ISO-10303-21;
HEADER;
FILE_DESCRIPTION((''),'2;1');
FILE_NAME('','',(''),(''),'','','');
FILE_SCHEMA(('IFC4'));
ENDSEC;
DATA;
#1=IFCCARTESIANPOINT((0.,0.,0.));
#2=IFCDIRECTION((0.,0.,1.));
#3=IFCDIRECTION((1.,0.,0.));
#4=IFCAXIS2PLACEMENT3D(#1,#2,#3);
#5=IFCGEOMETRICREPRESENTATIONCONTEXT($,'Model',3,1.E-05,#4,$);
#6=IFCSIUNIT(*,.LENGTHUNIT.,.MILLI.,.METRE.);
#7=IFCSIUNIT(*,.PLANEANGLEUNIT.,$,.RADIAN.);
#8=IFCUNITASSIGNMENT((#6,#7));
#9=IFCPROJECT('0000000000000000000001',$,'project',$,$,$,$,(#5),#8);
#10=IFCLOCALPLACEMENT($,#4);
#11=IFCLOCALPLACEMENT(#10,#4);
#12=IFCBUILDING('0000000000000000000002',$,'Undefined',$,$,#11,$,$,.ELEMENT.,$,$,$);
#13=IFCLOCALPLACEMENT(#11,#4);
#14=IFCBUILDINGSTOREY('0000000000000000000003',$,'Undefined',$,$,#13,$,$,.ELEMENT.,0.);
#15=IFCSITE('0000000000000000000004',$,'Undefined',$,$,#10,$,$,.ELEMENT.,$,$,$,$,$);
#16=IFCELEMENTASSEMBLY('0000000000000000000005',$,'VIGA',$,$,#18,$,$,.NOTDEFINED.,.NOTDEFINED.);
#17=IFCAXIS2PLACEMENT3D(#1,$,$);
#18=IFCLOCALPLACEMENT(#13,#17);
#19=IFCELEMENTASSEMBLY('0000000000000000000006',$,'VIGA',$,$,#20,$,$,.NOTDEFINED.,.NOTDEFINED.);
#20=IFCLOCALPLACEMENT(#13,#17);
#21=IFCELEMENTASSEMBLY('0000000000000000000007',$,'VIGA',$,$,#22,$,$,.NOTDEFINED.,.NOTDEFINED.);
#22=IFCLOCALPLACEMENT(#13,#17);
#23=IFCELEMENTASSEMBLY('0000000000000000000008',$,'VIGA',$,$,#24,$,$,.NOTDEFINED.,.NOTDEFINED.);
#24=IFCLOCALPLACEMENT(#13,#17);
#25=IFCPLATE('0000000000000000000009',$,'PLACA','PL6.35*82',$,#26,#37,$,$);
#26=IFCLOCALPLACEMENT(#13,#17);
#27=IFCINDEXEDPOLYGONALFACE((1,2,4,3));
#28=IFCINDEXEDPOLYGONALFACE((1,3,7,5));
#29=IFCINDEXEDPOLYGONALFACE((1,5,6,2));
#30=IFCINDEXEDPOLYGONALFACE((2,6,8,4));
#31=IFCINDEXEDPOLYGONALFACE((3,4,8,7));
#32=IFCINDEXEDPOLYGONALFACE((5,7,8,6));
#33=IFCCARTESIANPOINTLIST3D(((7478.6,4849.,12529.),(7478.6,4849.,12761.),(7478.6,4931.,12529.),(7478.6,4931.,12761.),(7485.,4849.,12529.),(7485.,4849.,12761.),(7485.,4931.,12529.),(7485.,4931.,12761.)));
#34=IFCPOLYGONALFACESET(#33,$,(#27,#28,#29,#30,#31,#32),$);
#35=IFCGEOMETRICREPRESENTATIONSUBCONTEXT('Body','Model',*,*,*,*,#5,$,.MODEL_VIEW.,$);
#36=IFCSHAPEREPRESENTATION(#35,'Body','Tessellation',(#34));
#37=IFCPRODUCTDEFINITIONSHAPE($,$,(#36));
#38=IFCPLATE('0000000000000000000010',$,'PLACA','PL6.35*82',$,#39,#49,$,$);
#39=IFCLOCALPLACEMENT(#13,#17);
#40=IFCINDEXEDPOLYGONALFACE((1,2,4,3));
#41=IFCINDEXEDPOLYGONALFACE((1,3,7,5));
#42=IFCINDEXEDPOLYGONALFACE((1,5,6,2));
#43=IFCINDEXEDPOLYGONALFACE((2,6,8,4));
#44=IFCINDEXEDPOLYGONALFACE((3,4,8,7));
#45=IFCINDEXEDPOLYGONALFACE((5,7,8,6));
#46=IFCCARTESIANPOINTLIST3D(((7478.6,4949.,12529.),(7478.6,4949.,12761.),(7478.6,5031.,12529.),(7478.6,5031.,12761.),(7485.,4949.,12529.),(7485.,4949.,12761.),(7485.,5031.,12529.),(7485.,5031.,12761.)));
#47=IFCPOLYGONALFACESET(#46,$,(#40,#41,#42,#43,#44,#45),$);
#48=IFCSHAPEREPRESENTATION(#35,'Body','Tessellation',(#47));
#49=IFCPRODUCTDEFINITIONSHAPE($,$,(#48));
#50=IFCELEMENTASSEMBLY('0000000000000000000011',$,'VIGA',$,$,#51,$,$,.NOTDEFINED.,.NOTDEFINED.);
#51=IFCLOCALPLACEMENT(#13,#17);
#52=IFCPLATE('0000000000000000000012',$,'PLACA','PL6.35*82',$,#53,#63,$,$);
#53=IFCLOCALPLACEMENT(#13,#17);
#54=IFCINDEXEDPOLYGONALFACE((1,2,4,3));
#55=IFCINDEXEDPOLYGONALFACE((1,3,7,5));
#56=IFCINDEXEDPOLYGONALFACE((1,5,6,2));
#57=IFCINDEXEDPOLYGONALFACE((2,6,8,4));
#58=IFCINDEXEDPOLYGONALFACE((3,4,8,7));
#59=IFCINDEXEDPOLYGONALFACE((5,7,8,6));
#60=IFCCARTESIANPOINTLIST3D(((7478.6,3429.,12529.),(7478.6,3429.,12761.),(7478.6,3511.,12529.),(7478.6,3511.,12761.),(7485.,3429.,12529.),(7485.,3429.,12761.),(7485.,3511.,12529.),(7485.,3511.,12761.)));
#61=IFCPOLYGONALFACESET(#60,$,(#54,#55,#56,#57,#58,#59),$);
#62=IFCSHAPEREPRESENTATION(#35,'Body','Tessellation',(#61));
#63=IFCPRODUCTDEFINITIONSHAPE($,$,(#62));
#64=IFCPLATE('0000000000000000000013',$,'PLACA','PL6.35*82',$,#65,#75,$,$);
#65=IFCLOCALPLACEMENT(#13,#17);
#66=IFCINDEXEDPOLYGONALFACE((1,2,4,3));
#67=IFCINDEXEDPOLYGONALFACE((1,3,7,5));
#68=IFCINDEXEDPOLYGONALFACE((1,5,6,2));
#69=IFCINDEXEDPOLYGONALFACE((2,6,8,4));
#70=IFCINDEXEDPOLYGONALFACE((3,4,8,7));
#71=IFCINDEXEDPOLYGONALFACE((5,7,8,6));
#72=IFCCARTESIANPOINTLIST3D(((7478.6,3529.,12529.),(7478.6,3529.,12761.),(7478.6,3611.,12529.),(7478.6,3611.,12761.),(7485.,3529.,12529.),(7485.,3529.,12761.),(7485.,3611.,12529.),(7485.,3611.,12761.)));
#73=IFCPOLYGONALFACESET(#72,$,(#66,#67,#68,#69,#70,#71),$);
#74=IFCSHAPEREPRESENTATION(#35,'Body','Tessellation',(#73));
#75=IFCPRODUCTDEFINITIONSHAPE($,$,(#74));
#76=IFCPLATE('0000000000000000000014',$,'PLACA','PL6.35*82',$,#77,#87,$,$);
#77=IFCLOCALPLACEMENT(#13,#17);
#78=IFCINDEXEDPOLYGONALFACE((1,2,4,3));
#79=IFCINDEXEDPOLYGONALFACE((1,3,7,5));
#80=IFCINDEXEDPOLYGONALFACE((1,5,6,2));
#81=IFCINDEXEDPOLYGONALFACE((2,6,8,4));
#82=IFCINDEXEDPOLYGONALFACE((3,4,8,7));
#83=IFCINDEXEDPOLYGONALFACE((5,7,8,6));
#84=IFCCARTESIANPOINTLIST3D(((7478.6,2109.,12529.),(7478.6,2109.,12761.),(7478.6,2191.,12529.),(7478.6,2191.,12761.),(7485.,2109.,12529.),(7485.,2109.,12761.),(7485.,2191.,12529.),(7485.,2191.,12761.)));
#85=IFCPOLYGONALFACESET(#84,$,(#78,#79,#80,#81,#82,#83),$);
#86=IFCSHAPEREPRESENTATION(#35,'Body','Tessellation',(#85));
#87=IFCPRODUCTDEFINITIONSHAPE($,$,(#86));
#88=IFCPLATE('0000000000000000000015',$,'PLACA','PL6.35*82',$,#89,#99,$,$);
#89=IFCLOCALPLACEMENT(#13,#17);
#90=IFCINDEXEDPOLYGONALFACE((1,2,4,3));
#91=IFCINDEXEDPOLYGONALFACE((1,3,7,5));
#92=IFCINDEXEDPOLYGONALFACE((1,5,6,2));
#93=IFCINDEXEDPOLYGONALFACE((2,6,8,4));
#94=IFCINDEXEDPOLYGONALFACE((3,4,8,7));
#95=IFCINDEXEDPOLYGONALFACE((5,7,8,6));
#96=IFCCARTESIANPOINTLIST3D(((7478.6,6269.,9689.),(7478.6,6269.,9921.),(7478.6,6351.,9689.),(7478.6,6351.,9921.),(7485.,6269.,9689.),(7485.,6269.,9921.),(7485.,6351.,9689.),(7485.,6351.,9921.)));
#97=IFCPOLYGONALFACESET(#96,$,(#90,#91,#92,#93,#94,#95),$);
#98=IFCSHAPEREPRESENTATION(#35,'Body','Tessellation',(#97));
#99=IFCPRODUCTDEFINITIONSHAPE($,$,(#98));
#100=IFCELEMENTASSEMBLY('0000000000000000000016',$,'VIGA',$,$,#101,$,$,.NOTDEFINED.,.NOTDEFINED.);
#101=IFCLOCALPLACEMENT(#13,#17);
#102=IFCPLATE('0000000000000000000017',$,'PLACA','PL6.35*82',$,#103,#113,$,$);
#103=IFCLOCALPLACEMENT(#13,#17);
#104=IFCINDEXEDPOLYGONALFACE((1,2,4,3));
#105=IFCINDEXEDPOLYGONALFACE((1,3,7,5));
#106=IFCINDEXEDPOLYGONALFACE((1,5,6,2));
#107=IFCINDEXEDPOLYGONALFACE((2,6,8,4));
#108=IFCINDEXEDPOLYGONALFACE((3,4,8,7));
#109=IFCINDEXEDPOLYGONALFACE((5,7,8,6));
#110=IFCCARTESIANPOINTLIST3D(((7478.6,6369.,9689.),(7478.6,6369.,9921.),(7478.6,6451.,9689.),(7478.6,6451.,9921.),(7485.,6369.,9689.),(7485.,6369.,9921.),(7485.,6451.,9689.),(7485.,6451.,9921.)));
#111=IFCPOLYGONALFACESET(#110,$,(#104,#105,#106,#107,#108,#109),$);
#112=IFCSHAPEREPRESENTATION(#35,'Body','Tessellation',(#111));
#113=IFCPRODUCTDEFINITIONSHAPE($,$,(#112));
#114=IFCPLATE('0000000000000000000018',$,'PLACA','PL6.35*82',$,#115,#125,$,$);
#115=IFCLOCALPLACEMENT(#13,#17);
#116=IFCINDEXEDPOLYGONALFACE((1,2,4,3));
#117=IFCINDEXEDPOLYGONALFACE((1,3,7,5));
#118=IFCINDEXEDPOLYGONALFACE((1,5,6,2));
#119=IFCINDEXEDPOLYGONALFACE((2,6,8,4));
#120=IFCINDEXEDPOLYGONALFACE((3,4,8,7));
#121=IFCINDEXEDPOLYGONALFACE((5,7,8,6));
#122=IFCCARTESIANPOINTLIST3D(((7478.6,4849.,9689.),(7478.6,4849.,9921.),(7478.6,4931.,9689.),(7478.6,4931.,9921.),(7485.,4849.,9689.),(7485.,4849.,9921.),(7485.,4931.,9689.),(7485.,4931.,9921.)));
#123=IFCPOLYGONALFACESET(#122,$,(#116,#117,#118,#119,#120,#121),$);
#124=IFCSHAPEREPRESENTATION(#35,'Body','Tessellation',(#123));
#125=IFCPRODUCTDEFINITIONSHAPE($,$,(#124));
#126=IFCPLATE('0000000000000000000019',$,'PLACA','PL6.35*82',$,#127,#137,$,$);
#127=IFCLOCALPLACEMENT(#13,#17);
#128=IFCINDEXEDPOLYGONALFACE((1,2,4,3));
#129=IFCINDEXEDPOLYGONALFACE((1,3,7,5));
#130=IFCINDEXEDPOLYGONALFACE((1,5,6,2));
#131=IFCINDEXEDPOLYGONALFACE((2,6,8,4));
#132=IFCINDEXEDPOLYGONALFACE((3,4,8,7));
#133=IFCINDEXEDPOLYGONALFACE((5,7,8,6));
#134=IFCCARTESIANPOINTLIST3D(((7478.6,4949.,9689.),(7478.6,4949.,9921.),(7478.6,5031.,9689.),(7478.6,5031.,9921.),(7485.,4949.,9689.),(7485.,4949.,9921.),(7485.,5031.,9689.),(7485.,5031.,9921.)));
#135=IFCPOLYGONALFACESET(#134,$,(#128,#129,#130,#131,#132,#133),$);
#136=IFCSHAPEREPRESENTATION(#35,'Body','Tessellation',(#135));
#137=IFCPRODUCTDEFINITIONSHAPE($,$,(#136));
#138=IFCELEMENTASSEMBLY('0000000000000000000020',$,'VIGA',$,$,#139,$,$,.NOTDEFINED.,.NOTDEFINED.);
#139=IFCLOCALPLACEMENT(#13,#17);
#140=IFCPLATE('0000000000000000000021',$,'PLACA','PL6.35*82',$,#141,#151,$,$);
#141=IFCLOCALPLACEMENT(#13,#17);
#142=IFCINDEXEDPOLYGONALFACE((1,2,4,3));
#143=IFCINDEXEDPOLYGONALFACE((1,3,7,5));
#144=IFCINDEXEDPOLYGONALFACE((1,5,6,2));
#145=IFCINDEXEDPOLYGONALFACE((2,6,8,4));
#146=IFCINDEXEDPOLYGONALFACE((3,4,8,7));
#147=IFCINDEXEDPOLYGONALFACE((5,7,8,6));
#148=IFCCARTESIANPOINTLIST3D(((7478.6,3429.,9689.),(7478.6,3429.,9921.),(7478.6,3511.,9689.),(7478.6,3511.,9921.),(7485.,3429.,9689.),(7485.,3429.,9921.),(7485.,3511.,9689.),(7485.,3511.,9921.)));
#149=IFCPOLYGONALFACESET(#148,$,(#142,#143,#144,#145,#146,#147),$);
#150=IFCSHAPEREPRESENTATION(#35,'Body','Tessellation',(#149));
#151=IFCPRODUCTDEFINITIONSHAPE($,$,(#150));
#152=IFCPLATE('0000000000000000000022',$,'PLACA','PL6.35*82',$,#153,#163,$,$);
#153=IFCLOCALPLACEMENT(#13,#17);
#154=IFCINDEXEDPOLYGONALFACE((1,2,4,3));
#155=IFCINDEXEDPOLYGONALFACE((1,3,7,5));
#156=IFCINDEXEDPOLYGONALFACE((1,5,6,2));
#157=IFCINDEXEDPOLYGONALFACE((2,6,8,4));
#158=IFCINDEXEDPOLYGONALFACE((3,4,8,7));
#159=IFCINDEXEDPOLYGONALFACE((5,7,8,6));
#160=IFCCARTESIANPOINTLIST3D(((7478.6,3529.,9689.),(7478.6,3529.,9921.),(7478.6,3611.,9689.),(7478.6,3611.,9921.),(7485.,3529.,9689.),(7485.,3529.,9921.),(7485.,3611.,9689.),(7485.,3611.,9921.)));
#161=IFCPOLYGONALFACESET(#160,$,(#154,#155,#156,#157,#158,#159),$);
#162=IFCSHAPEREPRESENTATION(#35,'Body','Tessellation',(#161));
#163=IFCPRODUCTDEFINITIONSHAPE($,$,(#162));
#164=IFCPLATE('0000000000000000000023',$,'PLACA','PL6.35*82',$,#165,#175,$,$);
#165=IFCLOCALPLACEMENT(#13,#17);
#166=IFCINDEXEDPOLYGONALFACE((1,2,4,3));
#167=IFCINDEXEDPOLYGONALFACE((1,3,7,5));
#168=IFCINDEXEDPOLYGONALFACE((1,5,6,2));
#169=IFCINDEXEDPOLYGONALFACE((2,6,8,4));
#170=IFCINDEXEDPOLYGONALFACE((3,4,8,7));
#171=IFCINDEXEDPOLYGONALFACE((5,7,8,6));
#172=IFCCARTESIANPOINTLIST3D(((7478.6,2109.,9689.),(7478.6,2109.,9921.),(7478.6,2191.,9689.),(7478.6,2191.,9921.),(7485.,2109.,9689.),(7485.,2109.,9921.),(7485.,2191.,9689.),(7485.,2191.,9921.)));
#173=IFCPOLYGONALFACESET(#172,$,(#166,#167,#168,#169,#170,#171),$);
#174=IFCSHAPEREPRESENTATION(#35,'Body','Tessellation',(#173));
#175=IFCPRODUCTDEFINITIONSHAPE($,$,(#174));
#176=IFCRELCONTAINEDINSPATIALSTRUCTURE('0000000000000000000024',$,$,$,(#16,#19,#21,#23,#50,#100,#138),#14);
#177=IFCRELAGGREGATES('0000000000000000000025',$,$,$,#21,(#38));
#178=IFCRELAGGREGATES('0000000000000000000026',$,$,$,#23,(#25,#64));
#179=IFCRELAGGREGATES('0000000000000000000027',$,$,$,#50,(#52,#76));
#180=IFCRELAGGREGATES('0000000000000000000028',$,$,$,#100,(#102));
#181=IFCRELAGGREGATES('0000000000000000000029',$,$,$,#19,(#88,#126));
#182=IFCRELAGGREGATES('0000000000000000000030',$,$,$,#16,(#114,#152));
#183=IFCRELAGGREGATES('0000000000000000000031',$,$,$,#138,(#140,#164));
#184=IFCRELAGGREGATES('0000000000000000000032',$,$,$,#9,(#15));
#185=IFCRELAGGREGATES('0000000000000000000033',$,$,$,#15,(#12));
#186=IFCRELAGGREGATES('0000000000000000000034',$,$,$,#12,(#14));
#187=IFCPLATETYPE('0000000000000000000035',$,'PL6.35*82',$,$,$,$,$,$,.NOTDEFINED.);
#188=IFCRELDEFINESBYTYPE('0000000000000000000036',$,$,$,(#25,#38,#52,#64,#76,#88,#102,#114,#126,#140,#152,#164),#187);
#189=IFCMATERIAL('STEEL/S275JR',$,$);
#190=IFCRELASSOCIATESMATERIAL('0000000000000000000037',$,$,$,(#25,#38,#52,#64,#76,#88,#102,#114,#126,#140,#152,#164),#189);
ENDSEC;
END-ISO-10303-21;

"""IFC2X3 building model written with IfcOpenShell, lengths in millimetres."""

from ifc_helpers import new_model, si_unit, frame, origin_with_axes, place, context, subcontext, project, spatial, polyline, outline, extrude, material, type_object, element, aggregate, save


model = new_model("IFC2X3")

# Units and contexts
model_context = context("Model", 3, precision=1e-05, world=origin_with_axes())
body_context = subcontext(model_context, "Body", "Model", "MODEL_VIEW")
ifc_project = project(units=[si_unit("LENGTHUNIT", "METRE", prefix="MILLI"), si_unit("PLANEANGLEUNIT", "RADIAN")], contexts=[model_context])

# Site, building, storey
site_placement = place(None, origin_with_axes())
site = spatial("IfcSite", under=ifc_project, at=site_placement, Name="Undefined", CompositionType="ELEMENT")
building_placement = place(site_placement, origin_with_axes())
building = spatial("IfcBuilding", under=site, at=building_placement, Name="Undefined", CompositionType="ELEMENT")
storey_placement = place(building_placement, origin_with_axes())
storey = spatial("IfcBuildingStorey", under=building, at=storey_placement, Name="Undefined", CompositionType="ELEMENT", Elevation=0.0)

# Shared definitions
ifc_material_1 = material(Name="STEEL/S275JR")

# Element assembly
assembly_1_placement = place(storey_placement, origin_with_axes())
assembly_1 = element("IfcElementAssembly", 1, at=assembly_1_placement, inside=storey, Name="VIGA", AssemblyPlace="NOTDEFINED", PredefinedType="NOTDEFINED")

# Element assemblies, plate
assembly_2_placement = place(storey_placement, origin_with_axes())
assembly_2 = element("IfcElementAssembly", 2, at=assembly_2_placement, inside=storey, Name="VIGA", AssemblyPlace="NOTDEFINED", PredefinedType="NOTDEFINED")
assembly_3_placement = place(storey_placement, origin_with_axes())
assembly_3 = element("IfcElementAssembly", 3, at=assembly_3_placement, inside=storey, Name="VIGA", AssemblyPlace="NOTDEFINED", PredefinedType="NOTDEFINED")
plate_type_1 = type_object("IfcPlateType", Name="PL6.35*82", PredefinedType="NOTDEFINED")
assembly_4_placement = place(storey_placement, origin_with_axes())
assembly_4 = element("IfcElementAssembly", 4, at=assembly_4_placement, inside=storey, Name="VIGA", AssemblyPlace="NOTDEFINED", PredefinedType="NOTDEFINED")
plate_1_placement = place(assembly_4_placement, frame((7481.8, 4849.0, 12761.0), z_axis=(-1.0, 0.0, 0.0), x_axis=(0.0, 1.0, 0.0)))
plate_1 = element("IfcPlate", 5, at=plate_1_placement, type_object=plate_type_1, material=ifc_material_1, Name="PLACA", Description="PL6.35*82", context=body_context, shape_type="SweptSolid", body=[
    extrude(outline(polyline([(0.0, 0.0), (82.0, 0.0), (82.0, 232.0), (0.0, 232.0), (0.0, 0.0)])), frame((0.0, 0.0, -3.2), z_axis=(0.0, 0.0, 1.0), x_axis=(1.0, 0.0, 0.0)), (0.0, 0.0, 1.0), 6.4),
])

# Plate
plate_2_placement = place(assembly_3_placement, frame((7481.8, 4949.0, 12761.0), z_axis=(-1.0, 0.0, 0.0), x_axis=(0.0, 1.0, 0.0)))
plate_2 = element("IfcPlate", 6, at=plate_2_placement, type_object=plate_type_1, material=ifc_material_1, Name="PLACA", Description="PL6.35*82", context=body_context, shape_type="SweptSolid", body=[
    extrude(outline(polyline([(0.0, 0.0), (82.0, 0.0), (82.0, 232.0), (0.0, 232.0), (0.0, 0.0)])), frame((0.0, 0.0, -3.2), z_axis=(0.0, 0.0, 1.0), x_axis=(1.0, 0.0, 0.0)), (0.0, 0.0, 1.0), 6.4),
])
aggregate(assembly_3, [plate_2])

# Element assembly, plate
assembly_5_placement = place(storey_placement, origin_with_axes())
assembly_5 = element("IfcElementAssembly", 7, at=assembly_5_placement, inside=storey, Name="VIGA", AssemblyPlace="NOTDEFINED", PredefinedType="NOTDEFINED")
plate_3_placement = place(assembly_5_placement, frame((7481.8, 3429.0, 12761.0), z_axis=(-1.0, 0.0, 0.0), x_axis=(0.0, 1.0, 0.0)))
plate_3 = element("IfcPlate", 8, at=plate_3_placement, type_object=plate_type_1, material=ifc_material_1, Name="PLACA", Description="PL6.35*82", context=body_context, shape_type="SweptSolid", body=[
    extrude(outline(polyline([(0.0, 0.0), (82.0, 0.0), (82.0, 232.0), (0.0, 232.0), (0.0, 0.0)])), frame((0.0, 0.0, -3.2), z_axis=(0.0, 0.0, 1.0), x_axis=(1.0, 0.0, 0.0)), (0.0, 0.0, 1.0), 6.4),
])

# Plates
plate_4_placement = place(assembly_4_placement, frame((7481.8, 3529.0, 12761.0), z_axis=(-1.0, 0.0, 0.0), x_axis=(0.0, 1.0, 0.0)))
plate_4 = element("IfcPlate", 9, at=plate_4_placement, type_object=plate_type_1, material=ifc_material_1, Name="PLACA", Description="PL6.35*82", context=body_context, shape_type="SweptSolid", body=[
    extrude(outline(polyline([(0.0, 0.0), (82.0, 0.0), (82.0, 232.0), (0.0, 232.0), (0.0, 0.0)])), frame((0.0, 0.0, -3.2), z_axis=(0.0, 0.0, 1.0), x_axis=(1.0, 0.0, 0.0)), (0.0, 0.0, 1.0), 6.4),
])
aggregate(assembly_4, [plate_1, plate_4])
plate_5_placement = place(assembly_5_placement, frame((7481.8, 2109.0, 12761.0), z_axis=(-1.0, 0.0, 0.0), x_axis=(0.0, 1.0, 0.0)))
plate_5 = element("IfcPlate", 10, at=plate_5_placement, type_object=plate_type_1, material=ifc_material_1, Name="PLACA", Description="PL6.35*82", context=body_context, shape_type="SweptSolid", body=[
    extrude(outline(polyline([(0.0, 0.0), (82.0, 0.0), (82.0, 232.0), (0.0, 232.0), (0.0, 0.0)])), frame((0.0, 0.0, -3.2), z_axis=(0.0, 0.0, 1.0), x_axis=(1.0, 0.0, 0.0)), (0.0, 0.0, 1.0), 6.4),
])
aggregate(assembly_5, [plate_3, plate_5])
plate_6_placement = place(assembly_2_placement, frame((7481.8, 6269.0, 9921.0), z_axis=(-1.0, 0.0, 0.0), x_axis=(0.0, 1.0, 0.0)))
plate_6 = element("IfcPlate", 11, at=plate_6_placement, type_object=plate_type_1, material=ifc_material_1, Name="PLACA", Description="PL6.35*82", context=body_context, shape_type="SweptSolid", body=[
    extrude(outline(polyline([(0.0, 0.0), (82.0, 0.0), (82.0, 232.0), (0.0, 232.0), (0.0, 0.0)])), frame((0.0, 0.0, -3.2), z_axis=(0.0, 0.0, 1.0), x_axis=(1.0, 0.0, 0.0)), (0.0, 0.0, 1.0), 6.4),
])

# Element assembly, plate
assembly_6_placement = place(storey_placement, origin_with_axes())
assembly_6 = element("IfcElementAssembly", 12, at=assembly_6_placement, inside=storey, Name="VIGA", AssemblyPlace="NOTDEFINED", PredefinedType="NOTDEFINED")
plate_7_placement = place(assembly_6_placement, frame((7481.8, 6369.0, 9921.0), z_axis=(-1.0, 0.0, 0.0), x_axis=(0.0, 1.0, 0.0)))
plate_7 = element("IfcPlate", 13, at=plate_7_placement, type_object=plate_type_1, material=ifc_material_1, Name="PLACA", Description="PL6.35*82", context=body_context, shape_type="SweptSolid", body=[
    extrude(outline(polyline([(0.0, 0.0), (82.0, 0.0), (82.0, 232.0), (0.0, 232.0), (0.0, 0.0)])), frame((0.0, 0.0, -3.2), z_axis=(0.0, 0.0, 1.0), x_axis=(1.0, 0.0, 0.0)), (0.0, 0.0, 1.0), 6.4),
])
aggregate(assembly_6, [plate_7])

# Plates
plate_8_placement = place(assembly_1_placement, frame((7481.8, 4849.0, 9921.0), z_axis=(-1.0, 0.0, 0.0), x_axis=(0.0, 1.0, 0.0)))
plate_8 = element("IfcPlate", 14, at=plate_8_placement, type_object=plate_type_1, material=ifc_material_1, Name="PLACA", Description="PL6.35*82", context=body_context, shape_type="SweptSolid", body=[
    extrude(outline(polyline([(0.0, 0.0), (82.0, 0.0), (82.0, 232.0), (0.0, 232.0), (0.0, 0.0)])), frame((0.0, 0.0, -3.2), z_axis=(0.0, 0.0, 1.0), x_axis=(1.0, 0.0, 0.0)), (0.0, 0.0, 1.0), 6.4),
])
plate_9_placement = place(assembly_2_placement, frame((7481.8, 4949.0, 9921.0), z_axis=(-1.0, 0.0, 0.0), x_axis=(0.0, 1.0, 0.0)))
plate_9 = element("IfcPlate", 15, at=plate_9_placement, type_object=plate_type_1, material=ifc_material_1, Name="PLACA", Description="PL6.35*82", context=body_context, shape_type="SweptSolid", body=[
    extrude(outline(polyline([(0.0, 0.0), (82.0, 0.0), (82.0, 232.0), (0.0, 232.0), (0.0, 0.0)])), frame((0.0, 0.0, -3.2), z_axis=(0.0, 0.0, 1.0), x_axis=(1.0, 0.0, 0.0)), (0.0, 0.0, 1.0), 6.4),
])
aggregate(assembly_2, [plate_6, plate_9])

# Element assembly, plate
assembly_7_placement = place(storey_placement, origin_with_axes())
assembly_7 = element("IfcElementAssembly", 16, at=assembly_7_placement, inside=storey, Name="VIGA", AssemblyPlace="NOTDEFINED", PredefinedType="NOTDEFINED")
plate_10_placement = place(assembly_7_placement, frame((7481.8, 3429.0, 9921.0), z_axis=(-1.0, 0.0, 0.0), x_axis=(0.0, 1.0, 0.0)))
plate_10 = element("IfcPlate", 17, at=plate_10_placement, type_object=plate_type_1, material=ifc_material_1, Name="PLACA", Description="PL6.35*82", context=body_context, shape_type="SweptSolid", body=[
    extrude(outline(polyline([(0.0, 0.0), (82.0, 0.0), (82.0, 232.0), (0.0, 232.0), (0.0, 0.0)])), frame((0.0, 0.0, -3.2), z_axis=(0.0, 0.0, 1.0), x_axis=(1.0, 0.0, 0.0)), (0.0, 0.0, 1.0), 6.4),
])

# Plates
plate_11_placement = place(assembly_1_placement, frame((7481.8, 3529.0, 9921.0), z_axis=(-1.0, 0.0, 0.0), x_axis=(0.0, 1.0, 0.0)))
plate_11 = element("IfcPlate", 18, at=plate_11_placement, type_object=plate_type_1, material=ifc_material_1, Name="PLACA", Description="PL6.35*82", context=body_context, shape_type="SweptSolid", body=[
    extrude(outline(polyline([(0.0, 0.0), (82.0, 0.0), (82.0, 232.0), (0.0, 232.0), (0.0, 0.0)])), frame((0.0, 0.0, -3.2), z_axis=(0.0, 0.0, 1.0), x_axis=(1.0, 0.0, 0.0)), (0.0, 0.0, 1.0), 6.4),
])
aggregate(assembly_1, [plate_8, plate_11])
plate_12_placement = place(assembly_7_placement, frame((7481.8, 2109.0, 9921.0), z_axis=(-1.0, 0.0, 0.0), x_axis=(0.0, 1.0, 0.0)))
plate_12 = element("IfcPlate", 19, at=plate_12_placement, type_object=plate_type_1, material=ifc_material_1, Name="PLACA", Description="PL6.35*82", context=body_context, shape_type="SweptSolid", body=[
    extrude(outline(polyline([(0.0, 0.0), (82.0, 0.0), (82.0, 232.0), (0.0, 232.0), (0.0, 0.0)])), frame((0.0, 0.0, -3.2), z_axis=(0.0, 0.0, 1.0), x_axis=(1.0, 0.0, 0.0)), (0.0, 0.0, 1.0), 6.4),
])
aggregate(assembly_7, [plate_10, plate_12])

save(model, "model.ifc")
